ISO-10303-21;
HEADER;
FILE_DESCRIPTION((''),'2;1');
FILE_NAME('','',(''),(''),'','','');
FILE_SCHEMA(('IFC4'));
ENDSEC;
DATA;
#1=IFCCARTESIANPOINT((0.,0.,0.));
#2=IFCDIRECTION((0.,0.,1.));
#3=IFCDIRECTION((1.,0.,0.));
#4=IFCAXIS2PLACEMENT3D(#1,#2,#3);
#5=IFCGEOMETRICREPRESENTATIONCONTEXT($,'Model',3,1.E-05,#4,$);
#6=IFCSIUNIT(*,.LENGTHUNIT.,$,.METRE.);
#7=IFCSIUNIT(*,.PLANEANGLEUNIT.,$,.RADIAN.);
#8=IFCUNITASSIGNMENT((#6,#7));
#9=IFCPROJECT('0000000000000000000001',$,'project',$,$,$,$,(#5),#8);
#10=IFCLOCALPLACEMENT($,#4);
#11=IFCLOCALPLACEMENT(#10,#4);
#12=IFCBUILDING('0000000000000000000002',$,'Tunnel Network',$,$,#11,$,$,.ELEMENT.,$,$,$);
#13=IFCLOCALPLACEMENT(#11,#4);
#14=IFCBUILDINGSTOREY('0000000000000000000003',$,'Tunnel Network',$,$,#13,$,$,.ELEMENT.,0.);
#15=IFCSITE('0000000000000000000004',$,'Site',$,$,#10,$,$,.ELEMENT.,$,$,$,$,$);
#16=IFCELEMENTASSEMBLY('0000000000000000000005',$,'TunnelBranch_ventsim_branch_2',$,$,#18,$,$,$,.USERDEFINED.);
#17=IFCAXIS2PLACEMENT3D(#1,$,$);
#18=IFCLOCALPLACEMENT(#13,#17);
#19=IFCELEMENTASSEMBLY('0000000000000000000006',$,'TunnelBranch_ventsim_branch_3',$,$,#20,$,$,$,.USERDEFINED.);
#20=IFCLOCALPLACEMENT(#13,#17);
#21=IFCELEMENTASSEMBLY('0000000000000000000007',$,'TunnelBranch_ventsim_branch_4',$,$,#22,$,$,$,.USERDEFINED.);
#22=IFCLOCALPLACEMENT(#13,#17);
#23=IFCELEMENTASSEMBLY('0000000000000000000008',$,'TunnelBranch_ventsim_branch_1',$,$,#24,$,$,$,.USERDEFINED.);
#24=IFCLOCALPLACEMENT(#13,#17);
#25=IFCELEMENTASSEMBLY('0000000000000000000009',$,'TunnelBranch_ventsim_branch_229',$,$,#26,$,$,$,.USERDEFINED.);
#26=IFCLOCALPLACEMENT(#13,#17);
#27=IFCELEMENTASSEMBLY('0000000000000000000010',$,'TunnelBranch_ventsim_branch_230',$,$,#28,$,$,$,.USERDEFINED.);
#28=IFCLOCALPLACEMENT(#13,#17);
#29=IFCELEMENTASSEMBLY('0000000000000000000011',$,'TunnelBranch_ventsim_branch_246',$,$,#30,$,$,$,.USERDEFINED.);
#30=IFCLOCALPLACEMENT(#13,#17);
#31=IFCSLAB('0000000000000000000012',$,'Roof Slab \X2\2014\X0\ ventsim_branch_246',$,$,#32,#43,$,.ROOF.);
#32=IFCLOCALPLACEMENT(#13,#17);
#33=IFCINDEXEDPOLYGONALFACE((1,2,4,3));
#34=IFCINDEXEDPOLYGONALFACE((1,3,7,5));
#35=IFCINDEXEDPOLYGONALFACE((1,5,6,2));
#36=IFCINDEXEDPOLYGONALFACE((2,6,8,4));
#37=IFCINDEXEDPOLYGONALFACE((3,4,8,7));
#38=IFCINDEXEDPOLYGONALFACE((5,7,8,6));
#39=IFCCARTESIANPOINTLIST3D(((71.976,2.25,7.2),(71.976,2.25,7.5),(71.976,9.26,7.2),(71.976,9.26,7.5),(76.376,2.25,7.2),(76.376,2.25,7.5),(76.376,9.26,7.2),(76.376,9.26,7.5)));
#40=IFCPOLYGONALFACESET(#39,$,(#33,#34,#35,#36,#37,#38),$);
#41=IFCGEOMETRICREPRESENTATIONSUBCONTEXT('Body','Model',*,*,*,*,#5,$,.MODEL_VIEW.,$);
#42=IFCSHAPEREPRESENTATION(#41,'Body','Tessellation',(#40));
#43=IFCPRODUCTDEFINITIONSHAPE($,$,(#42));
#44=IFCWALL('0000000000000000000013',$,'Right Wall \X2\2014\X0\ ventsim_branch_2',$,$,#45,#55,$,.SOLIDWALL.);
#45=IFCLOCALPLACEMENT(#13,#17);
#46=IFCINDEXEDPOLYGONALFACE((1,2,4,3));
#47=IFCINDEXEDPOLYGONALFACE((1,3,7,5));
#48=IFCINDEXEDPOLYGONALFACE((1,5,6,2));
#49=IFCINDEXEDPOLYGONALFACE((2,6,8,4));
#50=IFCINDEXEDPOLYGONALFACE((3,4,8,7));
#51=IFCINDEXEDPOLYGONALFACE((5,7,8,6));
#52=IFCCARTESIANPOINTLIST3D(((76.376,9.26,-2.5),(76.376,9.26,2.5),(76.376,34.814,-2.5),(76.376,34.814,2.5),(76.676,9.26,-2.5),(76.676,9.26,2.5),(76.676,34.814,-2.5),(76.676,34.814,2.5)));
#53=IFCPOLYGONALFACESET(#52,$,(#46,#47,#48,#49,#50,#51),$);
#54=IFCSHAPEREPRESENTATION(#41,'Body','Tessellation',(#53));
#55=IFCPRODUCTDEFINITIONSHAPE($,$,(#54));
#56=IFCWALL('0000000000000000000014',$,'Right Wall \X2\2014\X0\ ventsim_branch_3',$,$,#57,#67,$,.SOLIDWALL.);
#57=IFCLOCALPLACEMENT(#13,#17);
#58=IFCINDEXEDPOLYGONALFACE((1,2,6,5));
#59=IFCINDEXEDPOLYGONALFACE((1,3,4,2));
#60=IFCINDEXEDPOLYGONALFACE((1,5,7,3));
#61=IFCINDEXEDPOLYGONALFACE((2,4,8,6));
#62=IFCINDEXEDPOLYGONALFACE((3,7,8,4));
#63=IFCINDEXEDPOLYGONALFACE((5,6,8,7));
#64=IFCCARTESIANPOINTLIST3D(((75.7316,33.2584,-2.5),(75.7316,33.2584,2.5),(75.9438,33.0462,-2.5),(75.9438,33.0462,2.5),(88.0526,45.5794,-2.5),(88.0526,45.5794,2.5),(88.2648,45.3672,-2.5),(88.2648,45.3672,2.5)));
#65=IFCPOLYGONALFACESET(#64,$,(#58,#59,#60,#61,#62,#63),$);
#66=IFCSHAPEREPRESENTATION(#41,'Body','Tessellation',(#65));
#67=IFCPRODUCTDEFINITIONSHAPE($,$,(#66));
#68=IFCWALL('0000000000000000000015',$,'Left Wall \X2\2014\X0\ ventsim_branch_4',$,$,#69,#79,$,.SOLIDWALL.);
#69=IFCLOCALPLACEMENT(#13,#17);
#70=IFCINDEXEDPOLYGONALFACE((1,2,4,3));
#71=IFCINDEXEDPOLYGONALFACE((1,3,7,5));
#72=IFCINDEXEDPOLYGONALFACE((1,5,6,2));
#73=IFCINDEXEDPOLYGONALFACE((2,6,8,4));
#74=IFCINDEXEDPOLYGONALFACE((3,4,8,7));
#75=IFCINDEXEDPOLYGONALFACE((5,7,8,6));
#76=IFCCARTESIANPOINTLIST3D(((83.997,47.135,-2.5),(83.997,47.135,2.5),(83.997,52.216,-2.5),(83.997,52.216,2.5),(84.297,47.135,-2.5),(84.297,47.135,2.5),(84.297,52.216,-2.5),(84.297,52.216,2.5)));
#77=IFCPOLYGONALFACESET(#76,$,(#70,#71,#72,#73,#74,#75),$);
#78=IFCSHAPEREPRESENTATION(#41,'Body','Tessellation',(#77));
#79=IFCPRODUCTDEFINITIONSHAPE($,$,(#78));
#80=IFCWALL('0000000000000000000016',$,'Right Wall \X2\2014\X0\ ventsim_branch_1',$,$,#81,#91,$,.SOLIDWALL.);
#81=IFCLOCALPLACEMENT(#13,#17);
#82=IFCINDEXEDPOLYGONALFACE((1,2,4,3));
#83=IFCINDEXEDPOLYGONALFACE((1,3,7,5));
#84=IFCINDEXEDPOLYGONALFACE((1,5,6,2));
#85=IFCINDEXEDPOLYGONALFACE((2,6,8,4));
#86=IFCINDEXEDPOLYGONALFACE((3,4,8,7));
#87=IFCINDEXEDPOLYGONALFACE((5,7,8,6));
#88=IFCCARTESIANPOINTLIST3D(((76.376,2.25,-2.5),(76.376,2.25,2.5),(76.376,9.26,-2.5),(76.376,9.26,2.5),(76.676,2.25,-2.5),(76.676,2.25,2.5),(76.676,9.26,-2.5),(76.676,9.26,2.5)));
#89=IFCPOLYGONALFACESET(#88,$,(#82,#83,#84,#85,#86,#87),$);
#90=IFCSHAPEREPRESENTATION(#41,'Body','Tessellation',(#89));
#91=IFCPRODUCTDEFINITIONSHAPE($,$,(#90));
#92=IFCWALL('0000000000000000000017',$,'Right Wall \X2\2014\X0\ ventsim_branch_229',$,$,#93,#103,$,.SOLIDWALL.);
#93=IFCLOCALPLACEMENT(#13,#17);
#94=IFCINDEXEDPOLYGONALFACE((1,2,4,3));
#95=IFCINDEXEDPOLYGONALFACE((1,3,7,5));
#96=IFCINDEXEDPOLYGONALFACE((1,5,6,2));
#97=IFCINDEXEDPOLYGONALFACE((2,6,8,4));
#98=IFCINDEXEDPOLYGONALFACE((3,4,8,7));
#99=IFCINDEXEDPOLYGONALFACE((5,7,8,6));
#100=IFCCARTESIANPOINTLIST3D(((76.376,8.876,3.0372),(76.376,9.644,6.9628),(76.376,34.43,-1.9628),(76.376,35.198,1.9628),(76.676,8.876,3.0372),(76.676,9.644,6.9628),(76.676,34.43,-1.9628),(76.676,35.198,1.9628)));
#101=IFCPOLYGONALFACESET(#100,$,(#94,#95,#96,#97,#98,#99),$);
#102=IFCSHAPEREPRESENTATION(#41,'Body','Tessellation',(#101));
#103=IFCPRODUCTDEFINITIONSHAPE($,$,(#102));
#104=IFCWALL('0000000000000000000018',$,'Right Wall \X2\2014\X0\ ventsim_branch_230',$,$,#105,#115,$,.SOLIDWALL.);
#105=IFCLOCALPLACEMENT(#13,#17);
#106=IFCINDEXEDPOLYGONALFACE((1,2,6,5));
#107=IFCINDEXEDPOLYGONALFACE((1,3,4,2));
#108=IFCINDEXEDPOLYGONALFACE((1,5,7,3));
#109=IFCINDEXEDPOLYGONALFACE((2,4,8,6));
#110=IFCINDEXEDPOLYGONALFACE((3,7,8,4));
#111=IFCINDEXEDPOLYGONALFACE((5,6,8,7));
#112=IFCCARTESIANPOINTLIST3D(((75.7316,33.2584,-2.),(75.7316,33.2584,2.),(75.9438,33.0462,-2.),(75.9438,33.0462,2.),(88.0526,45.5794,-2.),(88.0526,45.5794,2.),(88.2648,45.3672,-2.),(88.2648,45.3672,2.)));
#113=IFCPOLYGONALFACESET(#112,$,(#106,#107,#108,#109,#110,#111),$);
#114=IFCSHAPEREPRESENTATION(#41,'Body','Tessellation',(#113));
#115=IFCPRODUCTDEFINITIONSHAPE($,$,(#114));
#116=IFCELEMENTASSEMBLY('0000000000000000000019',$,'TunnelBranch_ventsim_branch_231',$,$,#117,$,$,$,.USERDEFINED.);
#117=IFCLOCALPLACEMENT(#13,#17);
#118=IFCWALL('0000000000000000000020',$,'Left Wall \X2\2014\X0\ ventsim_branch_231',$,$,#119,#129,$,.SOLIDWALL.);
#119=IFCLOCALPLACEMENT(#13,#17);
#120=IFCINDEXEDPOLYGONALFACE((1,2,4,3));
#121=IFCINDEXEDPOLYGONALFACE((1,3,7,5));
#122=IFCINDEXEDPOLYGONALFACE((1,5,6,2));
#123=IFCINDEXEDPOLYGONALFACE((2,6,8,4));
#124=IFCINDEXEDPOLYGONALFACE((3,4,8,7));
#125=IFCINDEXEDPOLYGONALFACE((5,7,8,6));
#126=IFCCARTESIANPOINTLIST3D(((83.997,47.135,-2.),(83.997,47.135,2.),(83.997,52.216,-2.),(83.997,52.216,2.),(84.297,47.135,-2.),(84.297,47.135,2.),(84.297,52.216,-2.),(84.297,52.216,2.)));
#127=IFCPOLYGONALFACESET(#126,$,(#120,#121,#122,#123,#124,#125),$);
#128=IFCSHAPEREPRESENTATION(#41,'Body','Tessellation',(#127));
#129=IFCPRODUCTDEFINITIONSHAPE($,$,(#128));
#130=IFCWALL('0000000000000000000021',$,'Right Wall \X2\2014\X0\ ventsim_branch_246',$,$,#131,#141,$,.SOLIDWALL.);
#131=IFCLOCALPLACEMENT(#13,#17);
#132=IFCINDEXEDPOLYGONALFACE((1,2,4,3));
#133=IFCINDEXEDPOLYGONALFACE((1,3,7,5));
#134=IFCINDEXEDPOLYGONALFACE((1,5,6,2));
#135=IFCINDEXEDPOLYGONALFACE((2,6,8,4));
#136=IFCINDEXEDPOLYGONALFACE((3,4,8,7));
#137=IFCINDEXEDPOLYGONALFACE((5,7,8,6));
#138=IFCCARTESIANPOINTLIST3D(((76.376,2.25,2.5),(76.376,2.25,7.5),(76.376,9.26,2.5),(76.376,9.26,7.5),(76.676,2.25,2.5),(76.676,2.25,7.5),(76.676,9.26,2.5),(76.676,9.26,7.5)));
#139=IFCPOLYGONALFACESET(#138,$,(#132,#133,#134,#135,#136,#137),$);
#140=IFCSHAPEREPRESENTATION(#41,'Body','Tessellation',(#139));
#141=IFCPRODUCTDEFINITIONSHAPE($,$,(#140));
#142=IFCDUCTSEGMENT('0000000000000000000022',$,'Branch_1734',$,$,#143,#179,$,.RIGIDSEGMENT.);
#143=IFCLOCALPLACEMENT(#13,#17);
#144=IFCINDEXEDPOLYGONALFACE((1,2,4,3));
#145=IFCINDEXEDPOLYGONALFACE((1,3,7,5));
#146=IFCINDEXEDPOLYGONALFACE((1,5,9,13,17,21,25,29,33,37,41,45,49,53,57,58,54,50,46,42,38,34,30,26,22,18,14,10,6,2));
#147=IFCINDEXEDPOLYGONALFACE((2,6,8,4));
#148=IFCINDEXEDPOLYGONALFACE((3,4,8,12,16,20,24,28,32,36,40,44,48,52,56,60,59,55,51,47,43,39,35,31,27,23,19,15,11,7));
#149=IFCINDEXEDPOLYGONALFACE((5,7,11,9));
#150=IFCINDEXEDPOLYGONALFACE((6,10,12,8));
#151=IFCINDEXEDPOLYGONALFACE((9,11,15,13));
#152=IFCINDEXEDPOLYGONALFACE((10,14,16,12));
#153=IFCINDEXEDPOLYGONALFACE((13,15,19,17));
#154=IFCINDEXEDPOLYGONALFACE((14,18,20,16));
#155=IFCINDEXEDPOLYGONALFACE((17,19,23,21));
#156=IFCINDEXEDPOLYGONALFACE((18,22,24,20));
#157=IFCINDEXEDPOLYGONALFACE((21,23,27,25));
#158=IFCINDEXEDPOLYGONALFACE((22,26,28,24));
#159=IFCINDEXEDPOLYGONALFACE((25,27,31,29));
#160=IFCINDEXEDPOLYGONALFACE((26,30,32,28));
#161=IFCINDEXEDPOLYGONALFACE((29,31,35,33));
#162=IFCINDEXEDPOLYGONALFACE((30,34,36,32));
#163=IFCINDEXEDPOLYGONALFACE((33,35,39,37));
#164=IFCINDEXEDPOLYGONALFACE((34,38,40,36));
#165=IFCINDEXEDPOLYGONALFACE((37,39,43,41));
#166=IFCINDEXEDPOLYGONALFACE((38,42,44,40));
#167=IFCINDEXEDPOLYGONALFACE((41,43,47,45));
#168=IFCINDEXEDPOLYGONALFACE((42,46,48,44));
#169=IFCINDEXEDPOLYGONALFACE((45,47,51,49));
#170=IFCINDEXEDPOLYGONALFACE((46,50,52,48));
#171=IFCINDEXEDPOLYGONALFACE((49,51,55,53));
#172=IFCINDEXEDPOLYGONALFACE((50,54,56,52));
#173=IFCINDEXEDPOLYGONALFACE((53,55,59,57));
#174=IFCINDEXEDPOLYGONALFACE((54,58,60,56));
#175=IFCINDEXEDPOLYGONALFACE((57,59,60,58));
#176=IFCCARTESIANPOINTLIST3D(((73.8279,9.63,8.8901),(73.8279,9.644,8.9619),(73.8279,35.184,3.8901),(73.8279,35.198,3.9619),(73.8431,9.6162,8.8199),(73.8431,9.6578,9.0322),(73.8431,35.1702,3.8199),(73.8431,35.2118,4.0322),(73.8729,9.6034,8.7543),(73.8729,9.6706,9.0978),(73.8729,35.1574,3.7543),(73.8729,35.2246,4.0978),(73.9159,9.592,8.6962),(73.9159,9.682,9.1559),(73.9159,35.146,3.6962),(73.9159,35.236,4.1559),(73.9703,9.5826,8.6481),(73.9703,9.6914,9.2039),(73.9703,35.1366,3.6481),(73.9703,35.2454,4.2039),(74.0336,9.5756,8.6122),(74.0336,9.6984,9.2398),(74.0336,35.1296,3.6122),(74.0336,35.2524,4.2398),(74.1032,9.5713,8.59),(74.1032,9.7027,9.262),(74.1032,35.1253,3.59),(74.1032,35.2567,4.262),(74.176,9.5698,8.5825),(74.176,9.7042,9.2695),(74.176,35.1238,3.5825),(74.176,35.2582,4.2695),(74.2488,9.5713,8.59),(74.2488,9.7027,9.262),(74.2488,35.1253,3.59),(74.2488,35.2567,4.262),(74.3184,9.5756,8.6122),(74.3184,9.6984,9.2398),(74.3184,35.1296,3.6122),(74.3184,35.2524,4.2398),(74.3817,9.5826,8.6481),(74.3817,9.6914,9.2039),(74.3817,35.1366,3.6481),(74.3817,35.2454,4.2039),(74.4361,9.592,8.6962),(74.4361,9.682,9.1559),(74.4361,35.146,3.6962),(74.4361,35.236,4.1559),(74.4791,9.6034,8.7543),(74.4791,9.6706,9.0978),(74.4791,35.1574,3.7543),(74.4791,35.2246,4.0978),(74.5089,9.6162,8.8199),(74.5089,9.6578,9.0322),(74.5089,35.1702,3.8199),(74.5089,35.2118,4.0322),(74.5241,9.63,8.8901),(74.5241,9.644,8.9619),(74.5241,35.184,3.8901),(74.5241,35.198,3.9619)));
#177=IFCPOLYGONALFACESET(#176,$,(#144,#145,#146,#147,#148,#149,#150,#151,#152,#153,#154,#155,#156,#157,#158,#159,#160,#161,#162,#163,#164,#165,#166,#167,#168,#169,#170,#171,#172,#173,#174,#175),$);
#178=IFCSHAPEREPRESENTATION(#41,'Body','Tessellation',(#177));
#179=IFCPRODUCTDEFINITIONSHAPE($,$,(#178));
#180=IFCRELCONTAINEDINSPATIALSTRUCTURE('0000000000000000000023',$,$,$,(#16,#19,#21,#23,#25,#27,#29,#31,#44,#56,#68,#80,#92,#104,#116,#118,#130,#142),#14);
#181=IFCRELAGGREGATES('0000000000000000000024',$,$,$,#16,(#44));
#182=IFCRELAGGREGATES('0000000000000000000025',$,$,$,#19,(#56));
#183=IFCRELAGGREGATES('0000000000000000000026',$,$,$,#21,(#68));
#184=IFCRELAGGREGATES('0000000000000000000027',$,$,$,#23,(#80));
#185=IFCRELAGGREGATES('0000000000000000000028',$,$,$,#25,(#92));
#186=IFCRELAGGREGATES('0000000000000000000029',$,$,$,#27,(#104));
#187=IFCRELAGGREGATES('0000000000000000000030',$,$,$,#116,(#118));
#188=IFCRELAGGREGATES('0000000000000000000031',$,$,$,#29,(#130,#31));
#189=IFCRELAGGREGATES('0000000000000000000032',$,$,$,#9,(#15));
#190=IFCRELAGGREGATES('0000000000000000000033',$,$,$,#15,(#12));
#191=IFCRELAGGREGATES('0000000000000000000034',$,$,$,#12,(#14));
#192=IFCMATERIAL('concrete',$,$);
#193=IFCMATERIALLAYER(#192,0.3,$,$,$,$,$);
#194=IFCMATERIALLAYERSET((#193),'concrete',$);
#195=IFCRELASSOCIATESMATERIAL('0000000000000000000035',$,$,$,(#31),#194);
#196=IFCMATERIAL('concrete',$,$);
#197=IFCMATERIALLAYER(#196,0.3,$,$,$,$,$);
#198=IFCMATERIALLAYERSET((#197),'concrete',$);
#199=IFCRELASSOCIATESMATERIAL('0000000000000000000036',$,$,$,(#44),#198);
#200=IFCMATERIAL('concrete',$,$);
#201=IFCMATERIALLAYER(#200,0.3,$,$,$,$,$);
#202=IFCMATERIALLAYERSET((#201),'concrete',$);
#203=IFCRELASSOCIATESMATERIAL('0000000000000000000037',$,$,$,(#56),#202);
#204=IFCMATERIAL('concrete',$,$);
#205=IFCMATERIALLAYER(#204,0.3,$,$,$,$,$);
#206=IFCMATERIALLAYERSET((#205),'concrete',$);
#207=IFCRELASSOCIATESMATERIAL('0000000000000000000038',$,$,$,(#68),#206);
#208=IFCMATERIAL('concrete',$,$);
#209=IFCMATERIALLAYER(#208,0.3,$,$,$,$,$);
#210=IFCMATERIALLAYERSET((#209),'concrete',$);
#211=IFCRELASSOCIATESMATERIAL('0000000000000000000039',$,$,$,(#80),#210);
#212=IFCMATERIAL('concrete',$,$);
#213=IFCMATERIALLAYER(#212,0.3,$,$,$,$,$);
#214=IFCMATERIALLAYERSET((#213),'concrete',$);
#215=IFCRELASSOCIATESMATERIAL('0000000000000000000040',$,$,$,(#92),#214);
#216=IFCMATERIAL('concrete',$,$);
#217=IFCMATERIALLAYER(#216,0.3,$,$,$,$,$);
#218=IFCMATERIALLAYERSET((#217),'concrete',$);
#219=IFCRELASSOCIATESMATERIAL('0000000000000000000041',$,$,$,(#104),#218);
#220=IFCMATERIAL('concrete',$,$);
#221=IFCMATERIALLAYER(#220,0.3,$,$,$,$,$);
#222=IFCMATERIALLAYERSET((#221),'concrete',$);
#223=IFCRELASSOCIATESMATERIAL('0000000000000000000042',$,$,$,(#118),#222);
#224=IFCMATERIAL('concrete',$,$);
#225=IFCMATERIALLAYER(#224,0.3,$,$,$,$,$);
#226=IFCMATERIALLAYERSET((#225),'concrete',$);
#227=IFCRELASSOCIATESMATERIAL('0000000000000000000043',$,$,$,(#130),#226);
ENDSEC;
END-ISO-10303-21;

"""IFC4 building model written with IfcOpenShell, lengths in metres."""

from ifc_helpers import new_model, si_unit, frame, origin_with_axes, origin_2d_with_axis, place, context, subcontext, project, spatial, rectangle, circle, extrude, material, layer, layer_set, layer_usage, element, aggregate, save


model = new_model("IFC4")

# Units and contexts
model_context = context("Model", 3, precision=1e-05, world=origin_with_axes())
body_context = subcontext(model_context, "Body", "Model", "MODEL_VIEW")
ifc_project = project(units=[si_unit("LENGTHUNIT", "METRE"), si_unit("PLANEANGLEUNIT", "RADIAN")], contexts=[model_context])

# Site, building, storey
site_placement = place(None, origin_with_axes())
site = spatial("IfcSite", under=ifc_project, at=site_placement, Name="Site", CompositionType="ELEMENT")
building_placement = place(site_placement, origin_with_axes())
building = spatial("IfcBuilding", under=site, at=building_placement, Name="Tunnel Network", CompositionType="ELEMENT")
storey_placement = place(building_placement, origin_with_axes())
storey = spatial("IfcBuildingStorey", under=building, at=storey_placement, Name="Tunnel Network", CompositionType="ELEMENT", Elevation=0.0)

# Element assemblies, slab
assembly_1_placement = place(storey_placement, frame((71.826, 9.26, 0.0), z_axis=(0.0, 1.0, 0.0), x_axis=(1.0, 0.0, 0.0)))
assembly_1 = element("IfcElementAssembly", 1, at=assembly_1_placement, inside=storey, Name="TunnelBranch_ventsim_branch_2", PredefinedType="USERDEFINED")
assembly_2_placement = place(storey_placement, frame((72.5143, 36.4757, 0.0), z_axis=(0.707107, 0.707107, 0.0), x_axis=(0.707107, -0.707107, 0.0)))
assembly_2 = element("IfcElementAssembly", 2, at=assembly_2_placement, inside=storey, Name="TunnelBranch_ventsim_branch_3", PredefinedType="USERDEFINED")
assembly_3_placement = place(storey_placement, frame((84.147, 47.135, 0.0), z_axis=(0.0, 1.0, 0.0), x_axis=(1.0, 0.0, 0.0)))
assembly_3 = element("IfcElementAssembly", 3, at=assembly_3_placement, inside=storey, Name="TunnelBranch_ventsim_branch_4", PredefinedType="USERDEFINED")
assembly_4_placement = place(storey_placement, frame((71.826, 2.25, 0.0), z_axis=(0.0, 1.0, 0.0), x_axis=(1.0, 0.0, 0.0)))
assembly_4 = element("IfcElementAssembly", 4, at=assembly_4_placement, inside=storey, Name="TunnelBranch_ventsim_branch_1", PredefinedType="USERDEFINED")
assembly_5_placement = place(storey_placement, frame((71.826, 9.26, 5.0), z_axis=(0.0, 0.98139, -0.192023), x_axis=(1.0, 0.0, 0.0)))
assembly_5 = element("IfcElementAssembly", 5, at=assembly_5_placement, inside=storey, Name="TunnelBranch_ventsim_branch_229", PredefinedType="USERDEFINED")
assembly_6_placement = place(storey_placement, frame((72.5143, 36.4757, 0.0), z_axis=(0.707107, 0.707107, 0.0), x_axis=(0.707107, -0.707107, 0.0)))
assembly_6 = element("IfcElementAssembly", 6, at=assembly_6_placement, inside=storey, Name="TunnelBranch_ventsim_branch_230", PredefinedType="USERDEFINED")
assembly_7_placement = place(storey_placement, frame((71.826, 2.25, 5.0), z_axis=(0.0, 1.0, 0.0), x_axis=(1.0, 0.0, 0.0)))
assembly_7 = element("IfcElementAssembly", 7, at=assembly_7_placement, inside=storey, Name="TunnelBranch_ventsim_branch_246", PredefinedType="USERDEFINED")
ifc_material_1 = material(Name="concrete")
ifc_layer_1 = layer(ifc_material_1, 0.3)
ifc_layer_set_1 = layer_set([ifc_layer_1], Name="concrete")
ifc_layer_usage_1 = layer_usage(ifc_layer_set_1, "AXIS3", "POSITIVE", 0.0)
slab_1_placement = place(storey_placement, frame((74.176, 2.25, 7.35), z_axis=(0.0, 1.0, 0.0), x_axis=(1.0, 0.0, 0.0)))
slab_1 = element("IfcSlab", 8, at=slab_1_placement, inside=storey, material=ifc_layer_usage_1, Name="Roof Slab — ventsim_branch_246", PredefinedType="ROOF", context=body_context, shape_type="SweptSolid", body=[
    extrude(rectangle(XDim=4.4, YDim=0.3, at=origin_2d_with_axis()), origin_with_axes(), (0.0, 0.0, 1.0), 7.01),
])

# Walls
ifc_material_2 = material(Name="concrete")
ifc_layer_2 = layer(ifc_material_2, 0.3)
ifc_layer_set_2 = layer_set([ifc_layer_2], Name="concrete")
ifc_layer_usage_2 = layer_usage(ifc_layer_set_2, "AXIS2", "POSITIVE", 0.0)
wall_1_placement = place(storey_placement, frame((76.526, 9.26, 0.0), z_axis=(0.0, 1.0, 0.0), x_axis=(1.0, 0.0, 0.0)))
wall_1 = element("IfcWall", 9, at=wall_1_placement, inside=storey, material=ifc_layer_usage_2, Name="Right Wall — ventsim_branch_2", PredefinedType="SOLIDWALL", context=body_context, shape_type="SweptSolid", body=[
    extrude(rectangle(XDim=0.3, YDim=5.0, at=origin_2d_with_axis()), origin_with_axes(), (0.0, 0.0, 1.0), 25.554),
])
aggregate(assembly_1, [wall_1])
ifc_material_3 = material(Name="concrete")
ifc_layer_3 = layer(ifc_material_3, 0.3)
ifc_layer_set_3 = layer_set([ifc_layer_3], Name="concrete")
ifc_layer_usage_3 = layer_usage(ifc_layer_set_3, "AXIS2", "POSITIVE", 0.0)
wall_2_placement = place(storey_placement, frame((75.8377, 33.1523, 0.0), z_axis=(0.707107, 0.707107, 0.0), x_axis=(0.707107, -0.707107, 0.0)))
wall_2 = element("IfcWall", 10, at=wall_2_placement, inside=storey, material=ifc_layer_usage_3, Name="Right Wall — ventsim_branch_3", PredefinedType="SOLIDWALL", context=body_context, shape_type="SweptSolid", body=[
    extrude(rectangle(XDim=0.3, YDim=5.0, at=origin_2d_with_axis()), origin_with_axes(), (0.0, 0.0, 1.0), 17.4245),
])
aggregate(assembly_2, [wall_2])
ifc_material_4 = material(Name="concrete")
ifc_layer_4 = layer(ifc_material_4, 0.3)
ifc_layer_set_4 = layer_set([ifc_layer_4], Name="concrete")
ifc_layer_usage_4 = layer_usage(ifc_layer_set_4, "AXIS2", "POSITIVE", 0.0)
wall_3_placement = place(storey_placement, frame((84.147, 47.135, 0.0), z_axis=(0.0, 1.0, 0.0), x_axis=(1.0, 0.0, 0.0)))
wall_3 = element("IfcWall", 11, at=wall_3_placement, inside=storey, material=ifc_layer_usage_4, Name="Left Wall — ventsim_branch_4", PredefinedType="SOLIDWALL", context=body_context, shape_type="SweptSolid", body=[
    extrude(rectangle(XDim=0.3, YDim=5.0, at=origin_2d_with_axis()), origin_with_axes(), (0.0, 0.0, 1.0), 5.081),
])
aggregate(assembly_3, [wall_3])
ifc_material_5 = material(Name="concrete")
ifc_layer_5 = layer(ifc_material_5, 0.3)
ifc_layer_set_5 = layer_set([ifc_layer_5], Name="concrete")
ifc_layer_usage_5 = layer_usage(ifc_layer_set_5, "AXIS2", "POSITIVE", 0.0)
wall_4_placement = place(storey_placement, frame((76.526, 2.25, 0.0), z_axis=(0.0, 1.0, 0.0), x_axis=(1.0, 0.0, 0.0)))
wall_4 = element("IfcWall", 12, at=wall_4_placement, inside=storey, material=ifc_layer_usage_5, Name="Right Wall — ventsim_branch_1", PredefinedType="SOLIDWALL", context=body_context, shape_type="SweptSolid", body=[
    extrude(rectangle(XDim=0.3, YDim=5.0, at=origin_2d_with_axis()), origin_with_axes(), (0.0, 0.0, 1.0), 7.01),
])
aggregate(assembly_4, [wall_4])
ifc_material_6 = material(Name="concrete")
ifc_layer_6 = layer(ifc_material_6, 0.3)
ifc_layer_set_6 = layer_set([ifc_layer_6], Name="concrete")
ifc_layer_usage_6 = layer_usage(ifc_layer_set_6, "AXIS2", "POSITIVE", 0.0)
wall_5_placement = place(storey_placement, frame((76.526, 9.26, 5.0), z_axis=(0.0, 0.98139, -0.192023), x_axis=(1.0, 0.0, 0.0)))
wall_5 = element("IfcWall", 13, at=wall_5_placement, inside=storey, material=ifc_layer_usage_6, Name="Right Wall — ventsim_branch_229", PredefinedType="SOLIDWALL", context=body_context, shape_type="SweptSolid", body=[
    extrude(rectangle(XDim=0.3, YDim=4.0, at=origin_2d_with_axis()), origin_with_axes(), (0.0, 0.0, 1.0), 26.0386),
])
aggregate(assembly_5, [wall_5])
ifc_material_7 = material(Name="concrete")
ifc_layer_7 = layer(ifc_material_7, 0.3)
ifc_layer_set_7 = layer_set([ifc_layer_7], Name="concrete")
ifc_layer_usage_7 = layer_usage(ifc_layer_set_7, "AXIS2", "POSITIVE", 0.0)
wall_6_placement = place(storey_placement, frame((75.8377, 33.1523, 0.0), z_axis=(0.707107, 0.707107, 0.0), x_axis=(0.707107, -0.707107, 0.0)))
wall_6 = element("IfcWall", 14, at=wall_6_placement, inside=storey, material=ifc_layer_usage_7, Name="Right Wall — ventsim_branch_230", PredefinedType="SOLIDWALL", context=body_context, shape_type="SweptSolid", body=[
    extrude(rectangle(XDim=0.3, YDim=4.0, at=origin_2d_with_axis()), origin_with_axes(), (0.0, 0.0, 1.0), 17.4245),
])
aggregate(assembly_6, [wall_6])

# Element assembly, wall
assembly_8_placement = place(storey_placement, frame((84.147, 47.135, 0.0), z_axis=(0.0, 1.0, 0.0), x_axis=(1.0, 0.0, 0.0)))
assembly_8 = element("IfcElementAssembly", 15, at=assembly_8_placement, inside=storey, Name="TunnelBranch_ventsim_branch_231", PredefinedType="USERDEFINED")
ifc_material_8 = material(Name="concrete")
ifc_layer_8 = layer(ifc_material_8, 0.3)
ifc_layer_set_8 = layer_set([ifc_layer_8], Name="concrete")
ifc_layer_usage_8 = layer_usage(ifc_layer_set_8, "AXIS2", "POSITIVE", 0.0)
wall_7_placement = place(storey_placement, frame((84.147, 47.135, 0.0), z_axis=(0.0, 1.0, 0.0), x_axis=(1.0, 0.0, 0.0)))
wall_7 = element("IfcWall", 16, at=wall_7_placement, inside=storey, material=ifc_layer_usage_8, Name="Left Wall — ventsim_branch_231", PredefinedType="SOLIDWALL", context=body_context, shape_type="SweptSolid", body=[
    extrude(rectangle(XDim=0.3, YDim=4.0, at=origin_2d_with_axis()), origin_with_axes(), (0.0, 0.0, 1.0), 5.081),
])
aggregate(assembly_8, [wall_7])

# Wall
ifc_material_9 = material(Name="concrete")
ifc_layer_9 = layer(ifc_material_9, 0.3)
ifc_layer_set_9 = layer_set([ifc_layer_9], Name="concrete")
ifc_layer_usage_9 = layer_usage(ifc_layer_set_9, "AXIS2", "POSITIVE", 0.0)
wall_8_placement = place(storey_placement, frame((76.526, 2.25, 5.0), z_axis=(0.0, 1.0, 0.0), x_axis=(1.0, 0.0, 0.0)))
wall_8 = element("IfcWall", 17, at=wall_8_placement, inside=storey, material=ifc_layer_usage_9, Name="Right Wall — ventsim_branch_246", PredefinedType="SOLIDWALL", context=body_context, shape_type="SweptSolid", body=[
    extrude(rectangle(XDim=0.3, YDim=5.0, at=origin_2d_with_axis()), origin_with_axes(), (0.0, 0.0, 1.0), 7.01),
])
aggregate(assembly_7, [wall_8, slab_1])

# Duct segment
duct_segment_1_placement = place(storey_placement, frame((74.176, 9.637, 8.926), z_axis=(0.0, 0.98139, -0.192023), x_axis=(0.0, 0.192023, 0.98139)))
element("IfcDuctSegment", 18, at=duct_segment_1_placement, inside=storey, Name="Branch_1734", PredefinedType="RIGIDSEGMENT", context=body_context, shape_type="SweptSolid", body=[
    extrude(circle(Radius=0.35, at=origin_2d_with_axis()), origin_with_axes(), (0.0, 0.0, 1.0), 26.0386),
])

save(model, "model.ifc")
